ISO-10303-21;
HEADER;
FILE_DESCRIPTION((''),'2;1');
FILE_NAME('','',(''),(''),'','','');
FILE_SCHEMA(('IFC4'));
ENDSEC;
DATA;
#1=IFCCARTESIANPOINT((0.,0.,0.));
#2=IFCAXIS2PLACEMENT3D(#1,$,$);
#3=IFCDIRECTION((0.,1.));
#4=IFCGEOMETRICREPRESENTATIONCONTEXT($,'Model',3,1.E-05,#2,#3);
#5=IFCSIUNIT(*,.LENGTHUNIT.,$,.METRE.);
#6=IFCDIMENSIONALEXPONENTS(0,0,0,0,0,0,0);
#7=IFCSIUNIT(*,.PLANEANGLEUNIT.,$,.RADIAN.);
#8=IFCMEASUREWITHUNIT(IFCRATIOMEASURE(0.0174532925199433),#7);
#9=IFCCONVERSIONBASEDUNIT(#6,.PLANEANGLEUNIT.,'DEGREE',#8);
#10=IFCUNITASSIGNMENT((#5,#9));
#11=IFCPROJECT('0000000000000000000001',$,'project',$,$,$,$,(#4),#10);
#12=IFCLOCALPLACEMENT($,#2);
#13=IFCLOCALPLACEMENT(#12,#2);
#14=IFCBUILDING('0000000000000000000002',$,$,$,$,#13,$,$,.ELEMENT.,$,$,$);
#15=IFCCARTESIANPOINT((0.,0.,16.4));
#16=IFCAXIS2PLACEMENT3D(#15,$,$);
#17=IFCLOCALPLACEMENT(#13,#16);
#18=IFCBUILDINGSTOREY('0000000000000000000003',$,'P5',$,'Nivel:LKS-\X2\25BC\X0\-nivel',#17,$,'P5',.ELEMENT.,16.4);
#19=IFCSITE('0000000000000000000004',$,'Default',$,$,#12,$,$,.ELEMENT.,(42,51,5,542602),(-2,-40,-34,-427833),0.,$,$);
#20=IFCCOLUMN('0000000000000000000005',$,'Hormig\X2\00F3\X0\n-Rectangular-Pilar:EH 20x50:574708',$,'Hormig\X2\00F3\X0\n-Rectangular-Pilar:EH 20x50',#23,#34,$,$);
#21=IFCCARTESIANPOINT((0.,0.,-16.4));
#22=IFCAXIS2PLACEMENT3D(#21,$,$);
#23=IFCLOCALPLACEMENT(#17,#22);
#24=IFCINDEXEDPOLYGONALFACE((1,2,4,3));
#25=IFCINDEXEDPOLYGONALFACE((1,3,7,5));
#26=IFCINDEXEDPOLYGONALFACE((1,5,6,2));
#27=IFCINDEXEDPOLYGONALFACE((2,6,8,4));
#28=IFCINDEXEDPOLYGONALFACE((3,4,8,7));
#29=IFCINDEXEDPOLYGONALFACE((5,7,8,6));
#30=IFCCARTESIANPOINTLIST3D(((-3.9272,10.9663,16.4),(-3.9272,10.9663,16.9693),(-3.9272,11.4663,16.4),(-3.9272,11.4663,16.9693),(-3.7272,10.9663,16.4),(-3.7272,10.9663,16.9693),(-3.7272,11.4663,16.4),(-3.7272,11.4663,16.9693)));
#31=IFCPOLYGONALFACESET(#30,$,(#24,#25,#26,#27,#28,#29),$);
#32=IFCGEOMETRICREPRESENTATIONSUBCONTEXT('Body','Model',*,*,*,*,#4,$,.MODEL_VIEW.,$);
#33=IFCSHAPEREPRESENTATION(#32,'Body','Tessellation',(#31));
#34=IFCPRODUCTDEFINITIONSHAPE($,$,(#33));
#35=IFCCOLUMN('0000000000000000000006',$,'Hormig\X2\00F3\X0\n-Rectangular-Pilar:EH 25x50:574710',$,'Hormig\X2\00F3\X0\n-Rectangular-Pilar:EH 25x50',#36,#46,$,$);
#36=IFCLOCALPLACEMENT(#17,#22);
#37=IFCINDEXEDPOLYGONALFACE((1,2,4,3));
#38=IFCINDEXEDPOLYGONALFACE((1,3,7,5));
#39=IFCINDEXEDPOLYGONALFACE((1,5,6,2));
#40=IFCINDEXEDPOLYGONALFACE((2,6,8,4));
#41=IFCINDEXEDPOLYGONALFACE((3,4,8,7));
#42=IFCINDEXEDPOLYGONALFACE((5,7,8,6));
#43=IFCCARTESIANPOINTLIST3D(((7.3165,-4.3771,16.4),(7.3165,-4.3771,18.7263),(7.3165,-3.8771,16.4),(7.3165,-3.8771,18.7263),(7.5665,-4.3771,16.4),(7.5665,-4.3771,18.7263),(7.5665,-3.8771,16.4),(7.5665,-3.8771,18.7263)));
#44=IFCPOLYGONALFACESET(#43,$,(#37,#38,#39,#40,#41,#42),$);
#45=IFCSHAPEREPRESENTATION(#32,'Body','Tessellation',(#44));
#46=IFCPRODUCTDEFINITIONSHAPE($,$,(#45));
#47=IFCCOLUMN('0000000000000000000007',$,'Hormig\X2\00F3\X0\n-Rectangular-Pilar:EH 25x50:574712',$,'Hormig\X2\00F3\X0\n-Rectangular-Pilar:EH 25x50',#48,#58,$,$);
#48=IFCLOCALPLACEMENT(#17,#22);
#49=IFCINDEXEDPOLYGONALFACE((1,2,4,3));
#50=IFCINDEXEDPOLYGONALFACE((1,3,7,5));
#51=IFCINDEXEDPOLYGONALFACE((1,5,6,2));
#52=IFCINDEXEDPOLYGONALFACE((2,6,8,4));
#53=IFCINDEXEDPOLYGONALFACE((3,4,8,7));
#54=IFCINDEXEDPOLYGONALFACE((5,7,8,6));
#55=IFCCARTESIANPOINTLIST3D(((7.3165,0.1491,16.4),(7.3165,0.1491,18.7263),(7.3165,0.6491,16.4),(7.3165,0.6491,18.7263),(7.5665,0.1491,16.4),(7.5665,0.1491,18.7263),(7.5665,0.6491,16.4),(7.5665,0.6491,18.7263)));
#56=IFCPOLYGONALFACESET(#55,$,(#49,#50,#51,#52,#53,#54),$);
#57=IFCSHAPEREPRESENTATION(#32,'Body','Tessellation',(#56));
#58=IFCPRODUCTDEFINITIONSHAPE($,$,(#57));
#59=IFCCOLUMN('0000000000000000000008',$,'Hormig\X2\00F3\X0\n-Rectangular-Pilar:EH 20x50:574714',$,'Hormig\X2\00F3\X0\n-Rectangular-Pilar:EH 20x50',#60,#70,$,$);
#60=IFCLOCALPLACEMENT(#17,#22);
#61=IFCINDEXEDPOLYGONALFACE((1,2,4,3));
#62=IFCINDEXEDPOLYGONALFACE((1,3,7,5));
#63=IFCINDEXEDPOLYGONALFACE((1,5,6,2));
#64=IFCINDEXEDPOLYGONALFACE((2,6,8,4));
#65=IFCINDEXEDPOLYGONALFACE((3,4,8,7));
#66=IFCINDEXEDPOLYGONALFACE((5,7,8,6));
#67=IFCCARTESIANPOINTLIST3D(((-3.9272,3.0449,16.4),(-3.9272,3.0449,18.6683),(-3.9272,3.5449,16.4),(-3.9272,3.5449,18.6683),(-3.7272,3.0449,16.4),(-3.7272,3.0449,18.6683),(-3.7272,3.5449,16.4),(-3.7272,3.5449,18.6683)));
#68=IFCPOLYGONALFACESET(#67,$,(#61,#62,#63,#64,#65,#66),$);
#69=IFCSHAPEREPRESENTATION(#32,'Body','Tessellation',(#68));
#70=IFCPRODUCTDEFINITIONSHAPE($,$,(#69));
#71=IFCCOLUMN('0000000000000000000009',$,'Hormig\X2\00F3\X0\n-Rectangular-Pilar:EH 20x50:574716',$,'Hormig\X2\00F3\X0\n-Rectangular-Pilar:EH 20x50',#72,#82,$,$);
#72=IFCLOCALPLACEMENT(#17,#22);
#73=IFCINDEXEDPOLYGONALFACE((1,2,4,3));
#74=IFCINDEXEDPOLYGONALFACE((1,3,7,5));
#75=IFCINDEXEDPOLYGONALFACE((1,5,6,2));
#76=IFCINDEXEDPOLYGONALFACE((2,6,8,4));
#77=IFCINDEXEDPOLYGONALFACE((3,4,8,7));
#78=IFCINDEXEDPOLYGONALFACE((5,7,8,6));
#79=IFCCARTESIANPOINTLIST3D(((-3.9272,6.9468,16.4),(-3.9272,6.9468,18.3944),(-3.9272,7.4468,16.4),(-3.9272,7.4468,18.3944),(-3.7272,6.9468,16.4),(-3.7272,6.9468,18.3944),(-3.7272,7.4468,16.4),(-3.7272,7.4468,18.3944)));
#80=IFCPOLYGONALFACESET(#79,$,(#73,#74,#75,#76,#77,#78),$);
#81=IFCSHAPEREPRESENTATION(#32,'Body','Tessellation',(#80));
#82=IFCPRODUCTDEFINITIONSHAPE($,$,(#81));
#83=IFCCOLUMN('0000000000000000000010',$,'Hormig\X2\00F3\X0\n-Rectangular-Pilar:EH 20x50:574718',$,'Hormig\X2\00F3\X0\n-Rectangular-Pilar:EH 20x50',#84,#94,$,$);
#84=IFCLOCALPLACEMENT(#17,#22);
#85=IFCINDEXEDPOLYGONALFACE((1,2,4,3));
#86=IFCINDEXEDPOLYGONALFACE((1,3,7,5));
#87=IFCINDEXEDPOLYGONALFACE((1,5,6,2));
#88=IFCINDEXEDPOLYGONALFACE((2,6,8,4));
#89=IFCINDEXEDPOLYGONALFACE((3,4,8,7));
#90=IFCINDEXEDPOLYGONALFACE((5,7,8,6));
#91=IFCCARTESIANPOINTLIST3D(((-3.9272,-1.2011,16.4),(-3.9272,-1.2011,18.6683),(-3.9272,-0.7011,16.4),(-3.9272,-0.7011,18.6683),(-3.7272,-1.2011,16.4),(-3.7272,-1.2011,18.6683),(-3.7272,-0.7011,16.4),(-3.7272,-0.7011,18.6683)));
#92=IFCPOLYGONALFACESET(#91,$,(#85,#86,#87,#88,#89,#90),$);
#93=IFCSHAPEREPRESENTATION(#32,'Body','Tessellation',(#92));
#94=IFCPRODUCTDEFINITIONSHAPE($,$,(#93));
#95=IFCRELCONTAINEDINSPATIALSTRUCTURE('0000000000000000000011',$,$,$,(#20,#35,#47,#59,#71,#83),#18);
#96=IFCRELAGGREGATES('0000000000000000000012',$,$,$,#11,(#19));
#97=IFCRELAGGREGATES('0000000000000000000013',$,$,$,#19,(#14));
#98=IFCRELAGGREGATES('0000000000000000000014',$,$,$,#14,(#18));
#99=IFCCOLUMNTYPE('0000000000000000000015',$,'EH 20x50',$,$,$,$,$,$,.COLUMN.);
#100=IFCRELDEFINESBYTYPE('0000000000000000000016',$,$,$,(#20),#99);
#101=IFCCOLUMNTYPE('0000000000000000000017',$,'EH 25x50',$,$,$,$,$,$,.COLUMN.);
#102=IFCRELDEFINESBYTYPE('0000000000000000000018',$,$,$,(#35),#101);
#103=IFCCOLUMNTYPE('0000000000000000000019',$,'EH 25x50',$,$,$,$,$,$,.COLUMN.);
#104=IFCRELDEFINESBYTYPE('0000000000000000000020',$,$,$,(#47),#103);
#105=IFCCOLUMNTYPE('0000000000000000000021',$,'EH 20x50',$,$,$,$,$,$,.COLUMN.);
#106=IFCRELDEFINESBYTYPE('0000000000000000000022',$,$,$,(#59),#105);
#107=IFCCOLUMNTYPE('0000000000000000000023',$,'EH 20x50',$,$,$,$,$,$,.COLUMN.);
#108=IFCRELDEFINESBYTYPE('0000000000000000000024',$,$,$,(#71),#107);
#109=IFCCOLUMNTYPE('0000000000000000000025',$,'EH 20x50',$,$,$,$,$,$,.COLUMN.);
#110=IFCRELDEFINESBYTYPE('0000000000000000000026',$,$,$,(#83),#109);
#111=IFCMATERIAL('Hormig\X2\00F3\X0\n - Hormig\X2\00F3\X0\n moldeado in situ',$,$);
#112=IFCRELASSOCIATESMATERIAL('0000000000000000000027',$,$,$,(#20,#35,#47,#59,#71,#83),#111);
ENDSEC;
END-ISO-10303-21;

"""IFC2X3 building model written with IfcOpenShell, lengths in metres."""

from ifc_helpers import new_model, entity, si_unit, converted_unit, direction, frame, frame_2d, origin, origin_2d_with_axis, place, context, subcontext, project, spatial, rectangle, extrude, source, transform, mapped, material, type_object, type_shapes, element, save


model = new_model("IFC2X3")

# Units and contexts
model_context = context("Model", 3, precision=1e-05, world=origin(), true_north=direction((0.0, 1.0)))
body_context = subcontext(model_context, "Body", "Model", "MODEL_VIEW")
ifc_project = project(units=[si_unit("LENGTHUNIT", "METRE"), converted_unit("PLANEANGLEUNIT", "DEGREE", entity("IfcRatioMeasure", 0.0174532925199433), si_unit("PLANEANGLEUNIT", "RADIAN"), dimensions=[0, 0, 0, 0, 0, 0, 0])], contexts=[model_context])

# Site, building, storey
site_placement = place(None, origin())
site = spatial("IfcSite", under=ifc_project, at=site_placement, Name="Default", CompositionType="ELEMENT", RefLatitude=(42, 51, 5, 542602), RefLongitude=(-2, -40, -34, -427833), RefElevation=0.0)
building_placement = place(site_placement, origin())
building = spatial("IfcBuilding", under=site, at=building_placement, CompositionType="ELEMENT")
storey_placement = place(building_placement, frame((0.0, 0.0, 16.4)))
storey = spatial("IfcBuildingStorey", under=building, at=storey_placement, Name="P5", ObjectType="Nivel:LKS-▼-nivel", LongName="P5", CompositionType="ELEMENT", Elevation=16.4)

# Columns
ifc_material_1 = material(Name="Hormigón - Hormigón moldeado in situ")
column_type_1 = type_object("IfcColumnType", Name="EH 20x50", PredefinedType="COLUMN")
shared_shape_1 = source(origin(), body_context, "Body", "SweptSolid", [
    extrude(rectangle(XDim=0.5, YDim=0.2, at=origin_2d_with_axis()), frame((-3.8272, 11.2163, 16.4), z_axis=(0.0, 0.0, 1.0), x_axis=(0.0, -1.0, 0.0)), (0.0, 0.0, 1.0), 0.5693),
])
type_shapes(column_type_1, [shared_shape_1])
column_1_placement = place(storey_placement, frame((0.0, 0.0, -16.4)))
element("IfcColumn", 1, at=column_1_placement, inside=storey, type_object=column_type_1, material=ifc_material_1, Name="Hormigón-Rectangular-Pilar:EH 20x50:574708", ObjectType="Hormigón-Rectangular-Pilar:EH 20x50", context=body_context, shape_type="MappedRepresentation", body=[
    mapped(shared_shape_1, transform((0.0, 0.0, 0.0), scale=1.0)),
])
column_type_2 = type_object("IfcColumnType", Name="EH 25x50", PredefinedType="COLUMN")
shared_shape_2 = source(origin(), body_context, "Body", "SweptSolid", [
    extrude(rectangle(XDim=0.5, YDim=0.25, at=origin_2d_with_axis()), frame((7.4415, -4.1271, 16.4), z_axis=(0.0, 0.0, 1.0), x_axis=(0.0, -1.0, 0.0)), (0.0, 0.0, 1.0), 2.3263),
])
type_shapes(column_type_2, [shared_shape_2])
column_2_placement = place(storey_placement, frame((0.0, 0.0, -16.4)))
element("IfcColumn", 2, at=column_2_placement, inside=storey, type_object=column_type_2, material=ifc_material_1, Name="Hormigón-Rectangular-Pilar:EH 25x50:574710", ObjectType="Hormigón-Rectangular-Pilar:EH 25x50", context=body_context, shape_type="MappedRepresentation", body=[
    mapped(shared_shape_2, transform((0.0, 0.0, 0.0), scale=1.0)),
])
column_type_3 = type_object("IfcColumnType", Name="EH 25x50", PredefinedType="COLUMN")
shared_shape_3 = source(origin(), body_context, "Body", "SweptSolid", [
    extrude(rectangle(XDim=0.5, YDim=0.25, at=origin_2d_with_axis()), frame((7.4415, 0.3991, 16.4), z_axis=(0.0, 0.0, 1.0), x_axis=(0.0, -1.0, 0.0)), (0.0, 0.0, 1.0), 2.3263),
])
type_shapes(column_type_3, [shared_shape_3])
column_3_placement = place(storey_placement, frame((0.0, 0.0, -16.4)))
element("IfcColumn", 3, at=column_3_placement, inside=storey, type_object=column_type_3, material=ifc_material_1, Name="Hormigón-Rectangular-Pilar:EH 25x50:574712", ObjectType="Hormigón-Rectangular-Pilar:EH 25x50", context=body_context, shape_type="MappedRepresentation", body=[
    mapped(shared_shape_3, transform((0.0, 0.0, 0.0), scale=1.0)),
])
column_type_4 = type_object("IfcColumnType", Name="EH 20x50", PredefinedType="COLUMN")
shared_shape_4 = source(origin(), body_context, "Body", "SweptSolid", [
    extrude(rectangle(XDim=0.5, YDim=0.2, at=origin_2d_with_axis()), frame((-3.8272, 3.2949, 16.4), z_axis=(0.0, 0.0, 1.0), x_axis=(0.0, -1.0, 0.0)), (0.0, 0.0, 1.0), 2.2683),
])
type_shapes(column_type_4, [shared_shape_4])
column_4_placement = place(storey_placement, frame((0.0, 0.0, -16.4)))
element("IfcColumn", 4, at=column_4_placement, inside=storey, type_object=column_type_4, material=ifc_material_1, Name="Hormigón-Rectangular-Pilar:EH 20x50:574714", ObjectType="Hormigón-Rectangular-Pilar:EH 20x50", context=body_context, shape_type="MappedRepresentation", body=[
    mapped(shared_shape_4, transform((0.0, 0.0, 0.0), scale=1.0)),
])
column_type_5 = type_object("IfcColumnType", Name="EH 20x50", PredefinedType="COLUMN")
shared_shape_5 = source(origin(), body_context, "Body", "SweptSolid", [
    extrude(rectangle(XDim=0.5, YDim=0.2, at=origin_2d_with_axis()), frame((-3.8272, 7.1968, 16.4), z_axis=(0.0, 0.0, 1.0), x_axis=(0.0, -1.0, 0.0)), (0.0, 0.0, 1.0), 1.9944),
])
type_shapes(column_type_5, [shared_shape_5])
column_5_placement = place(storey_placement, frame((0.0, 0.0, -16.4)))
element("IfcColumn", 5, at=column_5_placement, inside=storey, type_object=column_type_5, material=ifc_material_1, Name="Hormigón-Rectangular-Pilar:EH 20x50:574716", ObjectType="Hormigón-Rectangular-Pilar:EH 20x50", context=body_context, shape_type="MappedRepresentation", body=[
    mapped(shared_shape_5, transform((0.0, 0.0, 0.0), scale=1.0)),
])
column_type_6 = type_object("IfcColumnType", Name="EH 20x50", PredefinedType="COLUMN")
shared_shape_6 = source(origin(), body_context, "Body", "SweptSolid", [
    extrude(rectangle(XDim=0.5, YDim=0.2, at=frame_2d((0.0, 0.0), x_axis=(1.0, 0.0))), frame((-3.8272, -0.9511, 16.4), z_axis=(0.0, 0.0, 1.0), x_axis=(0.0, -1.0, 0.0)), (0.0, 0.0, 1.0), 2.2683),
])
type_shapes(column_type_6, [shared_shape_6])
column_6_placement = place(storey_placement, frame((0.0, 0.0, -16.4)))
element("IfcColumn", 6, at=column_6_placement, inside=storey, type_object=column_type_6, material=ifc_material_1, Name="Hormigón-Rectangular-Pilar:EH 20x50:574718", ObjectType="Hormigón-Rectangular-Pilar:EH 20x50", context=body_context, shape_type="MappedRepresentation", body=[
    mapped(shared_shape_6, transform((0.0, 0.0, 0.0), scale=1.0)),
])

save(model, "model.ifc")
